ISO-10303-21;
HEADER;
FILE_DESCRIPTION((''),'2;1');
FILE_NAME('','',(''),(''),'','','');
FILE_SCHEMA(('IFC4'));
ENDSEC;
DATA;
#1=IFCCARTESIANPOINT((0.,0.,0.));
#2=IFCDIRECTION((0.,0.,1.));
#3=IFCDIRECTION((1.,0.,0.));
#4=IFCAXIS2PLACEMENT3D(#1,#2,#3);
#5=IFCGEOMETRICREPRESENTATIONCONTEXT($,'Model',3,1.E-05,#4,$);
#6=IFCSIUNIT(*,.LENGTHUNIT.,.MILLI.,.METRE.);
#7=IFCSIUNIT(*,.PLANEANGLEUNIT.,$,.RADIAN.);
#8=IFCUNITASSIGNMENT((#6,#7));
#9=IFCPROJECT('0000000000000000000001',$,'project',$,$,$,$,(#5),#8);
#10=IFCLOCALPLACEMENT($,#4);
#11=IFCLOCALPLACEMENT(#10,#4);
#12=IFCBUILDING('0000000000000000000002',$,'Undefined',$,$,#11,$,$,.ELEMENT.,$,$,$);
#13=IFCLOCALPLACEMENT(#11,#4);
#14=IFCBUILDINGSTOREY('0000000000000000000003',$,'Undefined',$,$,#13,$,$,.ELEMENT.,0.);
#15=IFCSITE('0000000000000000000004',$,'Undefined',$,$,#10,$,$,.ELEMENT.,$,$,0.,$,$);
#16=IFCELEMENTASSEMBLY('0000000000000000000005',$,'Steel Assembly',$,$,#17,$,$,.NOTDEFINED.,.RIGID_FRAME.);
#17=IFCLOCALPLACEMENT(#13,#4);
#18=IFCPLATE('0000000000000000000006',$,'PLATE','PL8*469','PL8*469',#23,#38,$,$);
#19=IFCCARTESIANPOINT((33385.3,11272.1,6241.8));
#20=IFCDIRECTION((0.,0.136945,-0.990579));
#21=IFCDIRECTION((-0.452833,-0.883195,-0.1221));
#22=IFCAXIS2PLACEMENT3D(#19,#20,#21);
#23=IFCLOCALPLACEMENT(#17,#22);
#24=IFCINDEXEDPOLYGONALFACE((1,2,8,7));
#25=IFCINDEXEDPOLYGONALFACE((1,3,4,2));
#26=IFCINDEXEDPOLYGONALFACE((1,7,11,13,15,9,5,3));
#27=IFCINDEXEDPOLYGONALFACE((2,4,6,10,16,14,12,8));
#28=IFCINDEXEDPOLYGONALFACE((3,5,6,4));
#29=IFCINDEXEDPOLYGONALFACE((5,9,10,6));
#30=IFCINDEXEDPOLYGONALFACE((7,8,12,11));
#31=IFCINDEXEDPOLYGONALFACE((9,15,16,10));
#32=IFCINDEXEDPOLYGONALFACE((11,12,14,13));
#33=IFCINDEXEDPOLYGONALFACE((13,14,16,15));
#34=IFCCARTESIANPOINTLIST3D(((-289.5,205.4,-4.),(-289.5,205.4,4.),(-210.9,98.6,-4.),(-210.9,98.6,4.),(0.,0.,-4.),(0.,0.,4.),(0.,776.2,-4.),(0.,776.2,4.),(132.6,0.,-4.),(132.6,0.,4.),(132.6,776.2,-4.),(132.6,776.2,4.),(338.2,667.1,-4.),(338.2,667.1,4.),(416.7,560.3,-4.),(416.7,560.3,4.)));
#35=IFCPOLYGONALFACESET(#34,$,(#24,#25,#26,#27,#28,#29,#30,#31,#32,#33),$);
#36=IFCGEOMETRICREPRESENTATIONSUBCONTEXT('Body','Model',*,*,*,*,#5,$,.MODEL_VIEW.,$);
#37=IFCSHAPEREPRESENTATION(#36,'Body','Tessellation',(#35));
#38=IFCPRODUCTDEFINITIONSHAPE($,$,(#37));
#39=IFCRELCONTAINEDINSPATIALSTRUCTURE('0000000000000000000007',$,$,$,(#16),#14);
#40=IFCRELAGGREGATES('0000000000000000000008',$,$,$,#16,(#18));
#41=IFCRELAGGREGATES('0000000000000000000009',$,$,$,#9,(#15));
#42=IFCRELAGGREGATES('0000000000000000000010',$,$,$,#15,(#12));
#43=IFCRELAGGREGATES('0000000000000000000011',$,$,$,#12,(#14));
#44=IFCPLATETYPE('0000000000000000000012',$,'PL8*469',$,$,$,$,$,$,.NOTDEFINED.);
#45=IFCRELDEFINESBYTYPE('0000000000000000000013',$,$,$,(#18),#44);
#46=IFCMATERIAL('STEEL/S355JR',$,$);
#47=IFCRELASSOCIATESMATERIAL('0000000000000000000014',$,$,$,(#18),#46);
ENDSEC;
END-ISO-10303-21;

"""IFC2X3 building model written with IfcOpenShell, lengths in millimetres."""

from ifc_helpers import new_model, si_unit, frame, origin_with_axes, place, context, subcontext, project, spatial, polyline, outline, extrude, material, type_object, element, aggregate, save


model = new_model("IFC2X3")

# Units and contexts
model_context = context("Model", 3, precision=1e-05, world=origin_with_axes())
body_context = subcontext(model_context, "Body", "Model", "MODEL_VIEW")
ifc_project = project(units=[si_unit("LENGTHUNIT", "METRE", prefix="MILLI"), si_unit("PLANEANGLEUNIT", "RADIAN")], contexts=[model_context])

# Site, building, storey
site_placement = place(None, origin_with_axes())
site = spatial("IfcSite", under=ifc_project, at=site_placement, Name="Undefined", CompositionType="ELEMENT", RefElevation=0.0)
building_placement = place(site_placement, origin_with_axes())
building = spatial("IfcBuilding", under=site, at=building_placement, Name="Undefined", CompositionType="ELEMENT")
storey_placement = place(building_placement, origin_with_axes())
storey = spatial("IfcBuildingStorey", under=building, at=storey_placement, Name="Undefined", CompositionType="ELEMENT", Elevation=0.0)

# Shared definitions
ifc_material_1 = material(Name="STEEL/S355JR")

# Element assembly, plate
assembly_1_placement = place(storey_placement, origin_with_axes())
assembly_1 = element("IfcElementAssembly", 1, at=assembly_1_placement, inside=storey, Name="Steel Assembly", AssemblyPlace="NOTDEFINED", PredefinedType="RIGID_FRAME")
plate_type_1 = type_object("IfcPlateType", Name="PL8*469", PredefinedType="NOTDEFINED")
plate_1_placement = place(assembly_1_placement, frame((33385.3, 11272.1, 6241.8), z_axis=(0.0, 0.136945, -0.990579), x_axis=(-0.452833, -0.883195, -0.1221)))
plate_1 = element("IfcPlate", 2, at=plate_1_placement, type_object=plate_type_1, material=ifc_material_1, Name="PLATE", Description="PL8*469", ObjectType="PL8*469", context=body_context, shape_type="SweptSolid", body=[
    extrude(outline(polyline([(0.0, 0.0), (132.6, 0.0), (416.7, 560.3), (338.2, 667.1), (132.6, 776.2), (0.0, 776.2), (-289.5, 205.4), (-210.9, 98.6), (0.0, 0.0)])), frame((0.0, 0.0, -4.0), z_axis=(0.0, 0.0, 1.0), x_axis=(1.0, 0.0, 0.0)), (0.0, 0.0, 1.0), 8.0),
])
aggregate(assembly_1, [plate_1])

save(model, "model.ifc")
